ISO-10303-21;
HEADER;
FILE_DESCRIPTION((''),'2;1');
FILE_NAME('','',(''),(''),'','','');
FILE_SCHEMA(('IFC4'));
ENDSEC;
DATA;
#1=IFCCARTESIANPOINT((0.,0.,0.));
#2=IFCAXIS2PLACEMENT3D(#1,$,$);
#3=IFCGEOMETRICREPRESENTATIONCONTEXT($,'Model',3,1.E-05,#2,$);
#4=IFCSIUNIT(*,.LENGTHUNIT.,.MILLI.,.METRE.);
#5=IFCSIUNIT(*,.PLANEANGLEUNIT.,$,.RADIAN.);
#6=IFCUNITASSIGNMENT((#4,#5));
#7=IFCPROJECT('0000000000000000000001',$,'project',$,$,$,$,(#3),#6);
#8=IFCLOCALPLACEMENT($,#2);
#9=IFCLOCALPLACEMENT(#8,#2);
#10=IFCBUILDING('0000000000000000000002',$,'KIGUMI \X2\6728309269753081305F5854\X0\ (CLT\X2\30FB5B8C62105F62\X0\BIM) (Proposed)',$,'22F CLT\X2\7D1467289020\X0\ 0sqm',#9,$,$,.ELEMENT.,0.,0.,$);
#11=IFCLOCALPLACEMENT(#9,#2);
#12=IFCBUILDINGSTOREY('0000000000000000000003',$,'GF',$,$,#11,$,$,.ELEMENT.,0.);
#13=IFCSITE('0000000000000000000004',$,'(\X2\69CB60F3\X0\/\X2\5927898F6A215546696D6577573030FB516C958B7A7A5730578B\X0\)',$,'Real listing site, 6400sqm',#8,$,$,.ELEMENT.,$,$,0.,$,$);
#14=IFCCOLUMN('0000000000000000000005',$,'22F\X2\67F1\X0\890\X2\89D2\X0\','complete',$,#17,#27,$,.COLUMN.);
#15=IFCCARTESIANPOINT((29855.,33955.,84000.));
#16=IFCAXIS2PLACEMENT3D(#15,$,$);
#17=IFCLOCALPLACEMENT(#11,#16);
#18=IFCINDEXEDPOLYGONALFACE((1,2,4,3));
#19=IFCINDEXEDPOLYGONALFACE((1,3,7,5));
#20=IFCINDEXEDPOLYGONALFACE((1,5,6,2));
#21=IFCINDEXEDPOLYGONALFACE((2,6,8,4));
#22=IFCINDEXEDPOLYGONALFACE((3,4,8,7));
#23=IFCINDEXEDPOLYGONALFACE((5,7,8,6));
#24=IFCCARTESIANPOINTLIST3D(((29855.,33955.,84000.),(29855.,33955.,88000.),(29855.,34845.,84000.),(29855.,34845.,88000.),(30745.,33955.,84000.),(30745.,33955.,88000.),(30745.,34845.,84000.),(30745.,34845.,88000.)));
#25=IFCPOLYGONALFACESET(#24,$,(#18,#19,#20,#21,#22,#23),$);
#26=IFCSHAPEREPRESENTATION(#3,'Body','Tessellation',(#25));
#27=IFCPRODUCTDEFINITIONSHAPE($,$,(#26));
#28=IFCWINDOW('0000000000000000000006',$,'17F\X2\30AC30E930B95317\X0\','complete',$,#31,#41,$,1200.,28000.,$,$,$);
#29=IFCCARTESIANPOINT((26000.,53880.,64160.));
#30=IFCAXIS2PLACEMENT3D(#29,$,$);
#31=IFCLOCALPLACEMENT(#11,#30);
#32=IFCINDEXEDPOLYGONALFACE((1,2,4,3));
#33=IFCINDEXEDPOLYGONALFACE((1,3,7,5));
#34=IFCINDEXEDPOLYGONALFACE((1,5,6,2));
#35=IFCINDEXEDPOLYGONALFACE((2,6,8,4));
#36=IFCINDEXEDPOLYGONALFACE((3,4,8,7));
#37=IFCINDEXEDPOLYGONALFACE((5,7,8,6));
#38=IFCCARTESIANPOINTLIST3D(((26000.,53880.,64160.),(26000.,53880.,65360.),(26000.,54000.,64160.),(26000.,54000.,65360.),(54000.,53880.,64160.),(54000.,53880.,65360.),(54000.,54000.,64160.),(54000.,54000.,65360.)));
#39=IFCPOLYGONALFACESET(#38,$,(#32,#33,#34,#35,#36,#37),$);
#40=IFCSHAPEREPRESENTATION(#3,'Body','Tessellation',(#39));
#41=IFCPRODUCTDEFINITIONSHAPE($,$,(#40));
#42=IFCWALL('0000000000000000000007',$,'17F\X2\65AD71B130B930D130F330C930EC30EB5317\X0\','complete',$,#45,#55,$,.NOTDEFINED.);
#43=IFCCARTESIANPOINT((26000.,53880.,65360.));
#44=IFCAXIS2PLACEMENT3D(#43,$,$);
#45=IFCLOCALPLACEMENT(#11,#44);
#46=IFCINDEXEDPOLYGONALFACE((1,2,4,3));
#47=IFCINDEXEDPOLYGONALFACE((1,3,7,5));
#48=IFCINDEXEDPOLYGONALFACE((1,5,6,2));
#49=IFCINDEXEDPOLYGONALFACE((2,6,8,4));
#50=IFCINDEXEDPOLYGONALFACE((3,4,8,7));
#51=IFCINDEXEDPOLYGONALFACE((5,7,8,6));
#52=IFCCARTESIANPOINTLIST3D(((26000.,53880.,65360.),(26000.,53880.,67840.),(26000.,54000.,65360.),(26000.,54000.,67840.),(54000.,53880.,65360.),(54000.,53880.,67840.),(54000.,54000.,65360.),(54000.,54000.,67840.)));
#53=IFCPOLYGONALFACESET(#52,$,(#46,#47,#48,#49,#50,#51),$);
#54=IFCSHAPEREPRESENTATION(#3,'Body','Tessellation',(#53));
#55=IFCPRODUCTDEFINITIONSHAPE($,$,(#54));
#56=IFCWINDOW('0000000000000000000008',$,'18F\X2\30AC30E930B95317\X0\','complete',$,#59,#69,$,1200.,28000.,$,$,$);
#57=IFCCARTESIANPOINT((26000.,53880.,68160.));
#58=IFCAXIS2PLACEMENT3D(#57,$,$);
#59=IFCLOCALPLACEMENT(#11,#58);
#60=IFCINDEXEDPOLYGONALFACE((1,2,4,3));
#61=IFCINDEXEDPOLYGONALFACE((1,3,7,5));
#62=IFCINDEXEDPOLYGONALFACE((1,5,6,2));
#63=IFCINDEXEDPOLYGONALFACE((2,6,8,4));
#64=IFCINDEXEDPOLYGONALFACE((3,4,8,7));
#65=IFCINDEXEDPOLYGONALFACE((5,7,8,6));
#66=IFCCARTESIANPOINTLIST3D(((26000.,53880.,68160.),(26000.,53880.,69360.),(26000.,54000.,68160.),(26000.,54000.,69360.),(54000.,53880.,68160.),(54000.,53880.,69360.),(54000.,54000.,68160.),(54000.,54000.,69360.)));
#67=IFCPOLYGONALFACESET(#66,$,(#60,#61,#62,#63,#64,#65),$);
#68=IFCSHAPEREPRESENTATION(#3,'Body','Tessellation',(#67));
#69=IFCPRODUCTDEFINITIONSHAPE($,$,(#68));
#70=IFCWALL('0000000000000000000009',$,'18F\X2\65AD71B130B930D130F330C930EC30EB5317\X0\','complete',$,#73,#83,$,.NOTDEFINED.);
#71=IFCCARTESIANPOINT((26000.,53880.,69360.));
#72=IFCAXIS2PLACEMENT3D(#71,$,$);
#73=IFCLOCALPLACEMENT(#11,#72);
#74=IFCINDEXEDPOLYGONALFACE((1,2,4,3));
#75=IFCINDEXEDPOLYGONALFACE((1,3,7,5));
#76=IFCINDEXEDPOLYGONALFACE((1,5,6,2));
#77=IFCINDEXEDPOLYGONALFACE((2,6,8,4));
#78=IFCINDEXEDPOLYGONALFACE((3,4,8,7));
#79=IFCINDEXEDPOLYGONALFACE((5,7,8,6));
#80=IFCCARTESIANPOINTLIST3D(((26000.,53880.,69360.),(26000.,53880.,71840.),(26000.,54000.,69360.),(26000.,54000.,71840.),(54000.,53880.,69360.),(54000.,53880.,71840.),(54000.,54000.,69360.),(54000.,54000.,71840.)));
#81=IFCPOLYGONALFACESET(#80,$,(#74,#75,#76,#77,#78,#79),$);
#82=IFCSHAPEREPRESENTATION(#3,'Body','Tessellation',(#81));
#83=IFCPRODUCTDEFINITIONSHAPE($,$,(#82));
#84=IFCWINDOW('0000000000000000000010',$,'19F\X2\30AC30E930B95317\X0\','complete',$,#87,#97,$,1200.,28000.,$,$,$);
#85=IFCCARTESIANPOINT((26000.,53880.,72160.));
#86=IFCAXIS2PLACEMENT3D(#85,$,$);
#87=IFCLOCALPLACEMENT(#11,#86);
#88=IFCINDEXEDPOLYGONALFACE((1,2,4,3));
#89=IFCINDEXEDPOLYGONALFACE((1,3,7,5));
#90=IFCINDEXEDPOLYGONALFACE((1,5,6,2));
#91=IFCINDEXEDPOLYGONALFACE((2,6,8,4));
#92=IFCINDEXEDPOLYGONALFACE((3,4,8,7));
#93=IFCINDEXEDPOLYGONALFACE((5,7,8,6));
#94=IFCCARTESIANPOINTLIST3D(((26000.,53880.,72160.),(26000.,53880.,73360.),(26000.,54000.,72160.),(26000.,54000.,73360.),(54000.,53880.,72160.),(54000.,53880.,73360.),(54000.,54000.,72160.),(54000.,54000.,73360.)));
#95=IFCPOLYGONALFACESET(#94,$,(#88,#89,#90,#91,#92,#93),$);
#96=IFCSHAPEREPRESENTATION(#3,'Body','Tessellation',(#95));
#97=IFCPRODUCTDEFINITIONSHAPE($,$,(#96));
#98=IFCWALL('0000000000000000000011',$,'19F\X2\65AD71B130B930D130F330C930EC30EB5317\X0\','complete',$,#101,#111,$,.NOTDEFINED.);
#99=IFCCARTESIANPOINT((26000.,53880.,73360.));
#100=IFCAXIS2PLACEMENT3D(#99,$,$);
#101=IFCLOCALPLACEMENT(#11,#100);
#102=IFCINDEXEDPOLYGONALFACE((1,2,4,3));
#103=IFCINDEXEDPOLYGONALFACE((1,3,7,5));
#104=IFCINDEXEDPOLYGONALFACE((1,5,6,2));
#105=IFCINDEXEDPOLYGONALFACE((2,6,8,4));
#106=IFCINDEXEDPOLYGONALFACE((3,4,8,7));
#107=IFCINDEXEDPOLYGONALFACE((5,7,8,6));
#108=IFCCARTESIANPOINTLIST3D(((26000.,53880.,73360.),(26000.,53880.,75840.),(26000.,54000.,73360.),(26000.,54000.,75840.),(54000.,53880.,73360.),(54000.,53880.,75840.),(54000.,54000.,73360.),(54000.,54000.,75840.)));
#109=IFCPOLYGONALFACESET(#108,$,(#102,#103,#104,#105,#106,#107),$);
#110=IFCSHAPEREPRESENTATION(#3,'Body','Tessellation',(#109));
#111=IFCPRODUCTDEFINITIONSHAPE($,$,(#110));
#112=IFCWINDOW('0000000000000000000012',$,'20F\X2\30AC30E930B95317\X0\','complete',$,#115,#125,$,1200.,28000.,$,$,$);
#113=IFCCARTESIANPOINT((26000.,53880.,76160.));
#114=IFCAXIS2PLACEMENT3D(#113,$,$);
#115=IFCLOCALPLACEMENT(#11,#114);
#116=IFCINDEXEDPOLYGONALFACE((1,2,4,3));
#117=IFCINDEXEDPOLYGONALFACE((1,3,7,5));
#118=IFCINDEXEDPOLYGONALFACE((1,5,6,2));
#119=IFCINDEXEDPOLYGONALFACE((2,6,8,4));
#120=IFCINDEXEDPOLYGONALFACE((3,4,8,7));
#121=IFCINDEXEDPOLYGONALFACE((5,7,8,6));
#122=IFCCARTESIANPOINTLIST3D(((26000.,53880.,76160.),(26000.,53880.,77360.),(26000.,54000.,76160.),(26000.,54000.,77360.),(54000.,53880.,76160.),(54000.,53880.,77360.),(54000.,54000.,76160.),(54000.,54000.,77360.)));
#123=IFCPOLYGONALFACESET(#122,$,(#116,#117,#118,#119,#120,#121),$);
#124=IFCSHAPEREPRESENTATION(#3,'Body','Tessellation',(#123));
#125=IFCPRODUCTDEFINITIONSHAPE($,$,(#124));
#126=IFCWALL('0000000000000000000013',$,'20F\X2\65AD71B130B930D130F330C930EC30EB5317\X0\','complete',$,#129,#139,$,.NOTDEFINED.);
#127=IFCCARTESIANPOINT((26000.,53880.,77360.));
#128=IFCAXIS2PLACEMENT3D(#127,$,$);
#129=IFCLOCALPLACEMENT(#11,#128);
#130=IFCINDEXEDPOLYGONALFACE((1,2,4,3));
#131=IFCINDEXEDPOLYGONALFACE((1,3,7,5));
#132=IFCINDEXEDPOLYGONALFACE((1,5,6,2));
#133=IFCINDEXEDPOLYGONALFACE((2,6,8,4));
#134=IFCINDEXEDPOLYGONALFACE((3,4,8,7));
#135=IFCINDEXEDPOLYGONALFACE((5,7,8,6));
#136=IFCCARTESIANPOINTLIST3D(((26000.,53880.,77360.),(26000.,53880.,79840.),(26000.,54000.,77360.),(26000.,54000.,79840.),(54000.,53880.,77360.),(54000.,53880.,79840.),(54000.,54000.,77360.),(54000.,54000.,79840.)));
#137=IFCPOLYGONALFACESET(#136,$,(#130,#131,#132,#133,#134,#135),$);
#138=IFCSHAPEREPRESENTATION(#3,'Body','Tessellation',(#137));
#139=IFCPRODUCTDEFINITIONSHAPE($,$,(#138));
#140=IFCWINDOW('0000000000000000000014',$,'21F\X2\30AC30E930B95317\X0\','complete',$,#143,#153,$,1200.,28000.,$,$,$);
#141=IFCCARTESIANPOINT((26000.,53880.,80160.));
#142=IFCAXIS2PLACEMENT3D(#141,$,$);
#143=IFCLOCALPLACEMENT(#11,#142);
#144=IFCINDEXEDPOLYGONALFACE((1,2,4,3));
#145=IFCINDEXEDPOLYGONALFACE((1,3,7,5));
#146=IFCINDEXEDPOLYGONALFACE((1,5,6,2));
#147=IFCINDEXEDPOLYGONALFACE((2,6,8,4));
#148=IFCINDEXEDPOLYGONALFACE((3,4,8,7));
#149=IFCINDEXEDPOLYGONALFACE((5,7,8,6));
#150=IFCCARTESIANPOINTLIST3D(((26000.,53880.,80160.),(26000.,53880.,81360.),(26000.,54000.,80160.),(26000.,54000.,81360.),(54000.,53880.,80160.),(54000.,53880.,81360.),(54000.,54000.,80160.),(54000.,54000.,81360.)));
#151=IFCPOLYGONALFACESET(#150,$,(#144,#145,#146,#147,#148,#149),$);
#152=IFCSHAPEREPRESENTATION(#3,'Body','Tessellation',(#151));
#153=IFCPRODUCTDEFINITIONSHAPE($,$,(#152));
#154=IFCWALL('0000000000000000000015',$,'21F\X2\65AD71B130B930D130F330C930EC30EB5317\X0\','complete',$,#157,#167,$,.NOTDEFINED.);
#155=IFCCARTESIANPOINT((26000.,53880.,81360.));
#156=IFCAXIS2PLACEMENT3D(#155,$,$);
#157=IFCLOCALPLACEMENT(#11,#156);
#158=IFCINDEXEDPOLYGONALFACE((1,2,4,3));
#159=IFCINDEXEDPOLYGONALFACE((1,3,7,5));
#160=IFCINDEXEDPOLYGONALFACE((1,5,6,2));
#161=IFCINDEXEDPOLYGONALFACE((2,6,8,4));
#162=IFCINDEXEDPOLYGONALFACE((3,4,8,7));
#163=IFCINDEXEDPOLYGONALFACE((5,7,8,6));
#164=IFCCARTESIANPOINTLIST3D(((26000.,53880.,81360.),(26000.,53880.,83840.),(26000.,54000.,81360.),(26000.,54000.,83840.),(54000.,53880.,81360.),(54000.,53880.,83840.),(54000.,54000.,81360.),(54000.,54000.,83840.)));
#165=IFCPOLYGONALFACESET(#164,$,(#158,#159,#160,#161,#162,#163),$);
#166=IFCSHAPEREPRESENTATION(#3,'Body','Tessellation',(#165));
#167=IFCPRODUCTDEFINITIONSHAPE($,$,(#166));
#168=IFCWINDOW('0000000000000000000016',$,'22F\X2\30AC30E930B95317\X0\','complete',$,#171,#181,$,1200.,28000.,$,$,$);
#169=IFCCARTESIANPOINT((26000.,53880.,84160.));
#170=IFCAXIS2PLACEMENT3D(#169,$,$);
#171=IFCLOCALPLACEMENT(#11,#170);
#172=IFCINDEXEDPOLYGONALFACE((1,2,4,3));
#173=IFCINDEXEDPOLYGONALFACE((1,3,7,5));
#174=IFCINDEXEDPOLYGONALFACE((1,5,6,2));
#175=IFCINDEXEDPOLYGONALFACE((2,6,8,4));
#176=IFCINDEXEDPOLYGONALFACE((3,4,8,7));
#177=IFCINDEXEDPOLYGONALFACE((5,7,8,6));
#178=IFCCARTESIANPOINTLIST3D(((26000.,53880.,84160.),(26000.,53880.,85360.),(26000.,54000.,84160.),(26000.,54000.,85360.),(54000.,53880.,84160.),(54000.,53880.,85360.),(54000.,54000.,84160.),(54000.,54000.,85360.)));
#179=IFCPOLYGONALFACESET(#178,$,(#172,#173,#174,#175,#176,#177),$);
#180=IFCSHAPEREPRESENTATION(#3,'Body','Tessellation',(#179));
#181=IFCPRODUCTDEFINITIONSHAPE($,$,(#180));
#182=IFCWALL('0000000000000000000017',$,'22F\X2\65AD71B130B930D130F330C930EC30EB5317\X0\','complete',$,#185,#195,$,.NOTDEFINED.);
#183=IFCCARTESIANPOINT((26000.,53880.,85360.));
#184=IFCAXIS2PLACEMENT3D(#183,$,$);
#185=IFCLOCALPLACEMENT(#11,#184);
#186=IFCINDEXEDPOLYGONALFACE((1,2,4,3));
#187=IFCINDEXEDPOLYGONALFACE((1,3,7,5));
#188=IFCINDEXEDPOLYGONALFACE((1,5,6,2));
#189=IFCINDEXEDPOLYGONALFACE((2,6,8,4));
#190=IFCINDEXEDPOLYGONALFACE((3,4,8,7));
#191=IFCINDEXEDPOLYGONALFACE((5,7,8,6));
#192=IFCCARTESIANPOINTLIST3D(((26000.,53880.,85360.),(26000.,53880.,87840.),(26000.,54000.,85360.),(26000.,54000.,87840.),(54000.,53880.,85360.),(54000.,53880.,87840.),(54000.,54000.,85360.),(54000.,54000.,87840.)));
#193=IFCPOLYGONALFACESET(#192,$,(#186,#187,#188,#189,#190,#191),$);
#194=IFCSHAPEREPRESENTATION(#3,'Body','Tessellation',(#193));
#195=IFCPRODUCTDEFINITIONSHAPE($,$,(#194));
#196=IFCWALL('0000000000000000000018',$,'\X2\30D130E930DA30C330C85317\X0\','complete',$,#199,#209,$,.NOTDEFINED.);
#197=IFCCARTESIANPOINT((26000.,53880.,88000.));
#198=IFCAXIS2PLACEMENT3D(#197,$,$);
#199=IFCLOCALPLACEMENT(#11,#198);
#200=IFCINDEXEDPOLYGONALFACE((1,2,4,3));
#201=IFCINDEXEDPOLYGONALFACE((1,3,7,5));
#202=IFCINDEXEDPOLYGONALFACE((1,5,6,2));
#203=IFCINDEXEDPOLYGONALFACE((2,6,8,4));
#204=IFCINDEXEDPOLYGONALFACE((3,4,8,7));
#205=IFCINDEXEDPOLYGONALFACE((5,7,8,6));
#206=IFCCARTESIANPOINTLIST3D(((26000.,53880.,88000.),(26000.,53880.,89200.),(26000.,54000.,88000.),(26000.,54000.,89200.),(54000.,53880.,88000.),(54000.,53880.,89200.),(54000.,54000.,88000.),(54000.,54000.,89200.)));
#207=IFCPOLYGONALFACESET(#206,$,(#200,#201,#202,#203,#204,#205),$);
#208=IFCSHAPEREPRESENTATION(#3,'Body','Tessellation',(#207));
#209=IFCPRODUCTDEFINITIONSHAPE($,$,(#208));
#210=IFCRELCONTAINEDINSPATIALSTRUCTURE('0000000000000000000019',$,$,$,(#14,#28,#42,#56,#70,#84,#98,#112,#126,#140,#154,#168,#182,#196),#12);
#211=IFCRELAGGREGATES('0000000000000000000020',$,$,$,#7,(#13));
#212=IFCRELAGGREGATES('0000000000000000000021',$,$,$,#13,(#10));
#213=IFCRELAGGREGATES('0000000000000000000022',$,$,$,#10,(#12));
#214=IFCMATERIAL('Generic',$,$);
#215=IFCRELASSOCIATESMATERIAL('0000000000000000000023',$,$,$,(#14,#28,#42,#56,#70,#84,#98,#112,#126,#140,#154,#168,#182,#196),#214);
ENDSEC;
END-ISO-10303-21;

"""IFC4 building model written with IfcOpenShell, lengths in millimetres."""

from ifc_helpers import new_model, si_unit, frame, frame_2d, origin, place, context, project, spatial, rectangle, extrude, material, element, save


model = new_model("IFC4")

# Units and contexts
model_context = context("Model", 3, precision=1e-05, world=origin())
ifc_project = project(units=[si_unit("LENGTHUNIT", "METRE", prefix="MILLI"), si_unit("PLANEANGLEUNIT", "RADIAN")], contexts=[model_context])

# Site, building, storey
site_placement = place(None, origin())
site = spatial("IfcSite", under=ifc_project, at=site_placement, Name="(構想/大規模商業敷地・公開空地型)", ObjectType="Real listing site, 6400sqm", CompositionType="ELEMENT", RefElevation=0.0)
building_placement = place(site_placement, origin())
building = spatial("IfcBuilding", under=site, at=building_placement, Name="KIGUMI 木を極めた塔 (CLT・完成形BIM) (Proposed)", ObjectType="22F CLT純木造 0sqm", CompositionType="ELEMENT", ElevationOfRefHeight=0.0, ElevationOfTerrain=0.0)
storey_placement = place(building_placement, origin())
storey = spatial("IfcBuildingStorey", under=building, at=storey_placement, Name="GF", CompositionType="ELEMENT", Elevation=0.0)

# Column
ifc_material = material(Name="Generic")
column_1_placement = place(storey_placement, frame((29855.0, 33955.0, 84000.0)))
element("IfcColumn", 1, at=column_1_placement, inside=storey, material=ifc_material, Name="22F柱890角", Description="complete", PredefinedType="COLUMN", context=model_context, shape_type="SweptSolid", body=[
    extrude(rectangle(XDim=890.0, YDim=890.0, at=frame_2d((445.0, 445.0))), frame((29855.0, 33955.0, 84000.0)), (0.0, 0.0, 1.0), 4000.0),
])

# Window
window_1_placement = place(storey_placement, frame((26000.0, 53880.0, 64160.0)))
element("IfcWindow", 2, at=window_1_placement, inside=storey, material=ifc_material, Name="17Fガラス北", Description="complete", OverallHeight=1200.0, OverallWidth=28000.0, context=model_context, shape_type="SweptSolid", body=[
    extrude(rectangle(XDim=28000.0, YDim=120.0, at=frame_2d((14000.0, 60.0))), frame((26000.0, 53880.0, 64160.0)), (0.0, 0.0, 1.0), 1200.0),
])

# Wall
wall_1_placement = place(storey_placement, frame((26000.0, 53880.0, 65360.0)))
element("IfcWall", 3, at=wall_1_placement, inside=storey, material=ifc_material, Name="17F断熱スパンドレル北", Description="complete", PredefinedType="NOTDEFINED", context=model_context, shape_type="SweptSolid", body=[
    extrude(rectangle(XDim=28000.0, YDim=120.0, at=frame_2d((14000.0, 60.0))), frame((26000.0, 53880.0, 65360.0)), (0.0, 0.0, 1.0), 2480.0),
])

# Window
window_2_placement = place(storey_placement, frame((26000.0, 53880.0, 68160.0)))
element("IfcWindow", 4, at=window_2_placement, inside=storey, material=ifc_material, Name="18Fガラス北", Description="complete", OverallHeight=1200.0, OverallWidth=28000.0, context=model_context, shape_type="SweptSolid", body=[
    extrude(rectangle(XDim=28000.0, YDim=120.0, at=frame_2d((14000.0, 60.0))), frame((26000.0, 53880.0, 68160.0)), (0.0, 0.0, 1.0), 1200.0),
])

# Wall
wall_2_placement = place(storey_placement, frame((26000.0, 53880.0, 69360.0)))
element("IfcWall", 5, at=wall_2_placement, inside=storey, material=ifc_material, Name="18F断熱スパンドレル北", Description="complete", PredefinedType="NOTDEFINED", context=model_context, shape_type="SweptSolid", body=[
    extrude(rectangle(XDim=28000.0, YDim=120.0, at=frame_2d((14000.0, 60.0))), frame((26000.0, 53880.0, 69360.0)), (0.0, 0.0, 1.0), 2480.0),
])

# Window
window_3_placement = place(storey_placement, frame((26000.0, 53880.0, 72160.0)))
element("IfcWindow", 6, at=window_3_placement, inside=storey, material=ifc_material, Name="19Fガラス北", Description="complete", OverallHeight=1200.0, OverallWidth=28000.0, context=model_context, shape_type="SweptSolid", body=[
    extrude(rectangle(XDim=28000.0, YDim=120.0, at=frame_2d((14000.0, 60.0))), frame((26000.0, 53880.0, 72160.0)), (0.0, 0.0, 1.0), 1200.0),
])

# Wall
wall_3_placement = place(storey_placement, frame((26000.0, 53880.0, 73360.0)))
element("IfcWall", 7, at=wall_3_placement, inside=storey, material=ifc_material, Name="19F断熱スパンドレル北", Description="complete", PredefinedType="NOTDEFINED", context=model_context, shape_type="SweptSolid", body=[
    extrude(rectangle(XDim=28000.0, YDim=120.0, at=frame_2d((14000.0, 60.0))), frame((26000.0, 53880.0, 73360.0)), (0.0, 0.0, 1.0), 2480.0),
])

# Window
window_4_placement = place(storey_placement, frame((26000.0, 53880.0, 76160.0)))
element("IfcWindow", 8, at=window_4_placement, inside=storey, material=ifc_material, Name="20Fガラス北", Description="complete", OverallHeight=1200.0, OverallWidth=28000.0, context=model_context, shape_type="SweptSolid", body=[
    extrude(rectangle(XDim=28000.0, YDim=120.0, at=frame_2d((14000.0, 60.0))), frame((26000.0, 53880.0, 76160.0)), (0.0, 0.0, 1.0), 1200.0),
])

# Wall
wall_4_placement = place(storey_placement, frame((26000.0, 53880.0, 77360.0)))
element("IfcWall", 9, at=wall_4_placement, inside=storey, material=ifc_material, Name="20F断熱スパンドレル北", Description="complete", PredefinedType="NOTDEFINED", context=model_context, shape_type="SweptSolid", body=[
    extrude(rectangle(XDim=28000.0, YDim=120.0, at=frame_2d((14000.0, 60.0))), frame((26000.0, 53880.0, 77360.0)), (0.0, 0.0, 1.0), 2480.0),
])

# Window
window_5_placement = place(storey_placement, frame((26000.0, 53880.0, 80160.0)))
element("IfcWindow", 10, at=window_5_placement, inside=storey, material=ifc_material, Name="21Fガラス北", Description="complete", OverallHeight=1200.0, OverallWidth=28000.0, context=model_context, shape_type="SweptSolid", body=[
    extrude(rectangle(XDim=28000.0, YDim=120.0, at=frame_2d((14000.0, 60.0))), frame((26000.0, 53880.0, 80160.0)), (0.0, 0.0, 1.0), 1200.0),
])

# Wall
wall_5_placement = place(storey_placement, frame((26000.0, 53880.0, 81360.0)))
element("IfcWall", 11, at=wall_5_placement, inside=storey, material=ifc_material, Name="21F断熱スパンドレル北", Description="complete", PredefinedType="NOTDEFINED", context=model_context, shape_type="SweptSolid", body=[
    extrude(rectangle(XDim=28000.0, YDim=120.0, at=frame_2d((14000.0, 60.0))), frame((26000.0, 53880.0, 81360.0)), (0.0, 0.0, 1.0), 2480.0),
])

# Window
window_6_placement = place(storey_placement, frame((26000.0, 53880.0, 84160.0)))
element("IfcWindow", 12, at=window_6_placement, inside=storey, material=ifc_material, Name="22Fガラス北", Description="complete", OverallHeight=1200.0, OverallWidth=28000.0, context=model_context, shape_type="SweptSolid", body=[
    extrude(rectangle(XDim=28000.0, YDim=120.0, at=frame_2d((14000.0, 60.0))), frame((26000.0, 53880.0, 84160.0)), (0.0, 0.0, 1.0), 1200.0),
])

# Walls
wall_6_placement = place(storey_placement, frame((26000.0, 53880.0, 85360.0)))
element("IfcWall", 13, at=wall_6_placement, inside=storey, material=ifc_material, Name="22F断熱スパンドレル北", Description="complete", PredefinedType="NOTDEFINED", context=model_context, shape_type="SweptSolid", body=[
    extrude(rectangle(XDim=28000.0, YDim=120.0, at=frame_2d((14000.0, 60.0))), frame((26000.0, 53880.0, 85360.0)), (0.0, 0.0, 1.0), 2480.0),
])
wall_7_placement = place(storey_placement, frame((26000.0, 53880.0, 88000.0)))
element("IfcWall", 14, at=wall_7_placement, inside=storey, material=ifc_material, Name="パラペット北", Description="complete", PredefinedType="NOTDEFINED", context=model_context, shape_type="SweptSolid", body=[
    extrude(rectangle(XDim=28000.0, YDim=120.0, at=frame_2d((14000.0, 60.0))), frame((26000.0, 53880.0, 88000.0)), (0.0, 0.0, 1.0), 1200.0),
])

save(model, "model.ifc")
